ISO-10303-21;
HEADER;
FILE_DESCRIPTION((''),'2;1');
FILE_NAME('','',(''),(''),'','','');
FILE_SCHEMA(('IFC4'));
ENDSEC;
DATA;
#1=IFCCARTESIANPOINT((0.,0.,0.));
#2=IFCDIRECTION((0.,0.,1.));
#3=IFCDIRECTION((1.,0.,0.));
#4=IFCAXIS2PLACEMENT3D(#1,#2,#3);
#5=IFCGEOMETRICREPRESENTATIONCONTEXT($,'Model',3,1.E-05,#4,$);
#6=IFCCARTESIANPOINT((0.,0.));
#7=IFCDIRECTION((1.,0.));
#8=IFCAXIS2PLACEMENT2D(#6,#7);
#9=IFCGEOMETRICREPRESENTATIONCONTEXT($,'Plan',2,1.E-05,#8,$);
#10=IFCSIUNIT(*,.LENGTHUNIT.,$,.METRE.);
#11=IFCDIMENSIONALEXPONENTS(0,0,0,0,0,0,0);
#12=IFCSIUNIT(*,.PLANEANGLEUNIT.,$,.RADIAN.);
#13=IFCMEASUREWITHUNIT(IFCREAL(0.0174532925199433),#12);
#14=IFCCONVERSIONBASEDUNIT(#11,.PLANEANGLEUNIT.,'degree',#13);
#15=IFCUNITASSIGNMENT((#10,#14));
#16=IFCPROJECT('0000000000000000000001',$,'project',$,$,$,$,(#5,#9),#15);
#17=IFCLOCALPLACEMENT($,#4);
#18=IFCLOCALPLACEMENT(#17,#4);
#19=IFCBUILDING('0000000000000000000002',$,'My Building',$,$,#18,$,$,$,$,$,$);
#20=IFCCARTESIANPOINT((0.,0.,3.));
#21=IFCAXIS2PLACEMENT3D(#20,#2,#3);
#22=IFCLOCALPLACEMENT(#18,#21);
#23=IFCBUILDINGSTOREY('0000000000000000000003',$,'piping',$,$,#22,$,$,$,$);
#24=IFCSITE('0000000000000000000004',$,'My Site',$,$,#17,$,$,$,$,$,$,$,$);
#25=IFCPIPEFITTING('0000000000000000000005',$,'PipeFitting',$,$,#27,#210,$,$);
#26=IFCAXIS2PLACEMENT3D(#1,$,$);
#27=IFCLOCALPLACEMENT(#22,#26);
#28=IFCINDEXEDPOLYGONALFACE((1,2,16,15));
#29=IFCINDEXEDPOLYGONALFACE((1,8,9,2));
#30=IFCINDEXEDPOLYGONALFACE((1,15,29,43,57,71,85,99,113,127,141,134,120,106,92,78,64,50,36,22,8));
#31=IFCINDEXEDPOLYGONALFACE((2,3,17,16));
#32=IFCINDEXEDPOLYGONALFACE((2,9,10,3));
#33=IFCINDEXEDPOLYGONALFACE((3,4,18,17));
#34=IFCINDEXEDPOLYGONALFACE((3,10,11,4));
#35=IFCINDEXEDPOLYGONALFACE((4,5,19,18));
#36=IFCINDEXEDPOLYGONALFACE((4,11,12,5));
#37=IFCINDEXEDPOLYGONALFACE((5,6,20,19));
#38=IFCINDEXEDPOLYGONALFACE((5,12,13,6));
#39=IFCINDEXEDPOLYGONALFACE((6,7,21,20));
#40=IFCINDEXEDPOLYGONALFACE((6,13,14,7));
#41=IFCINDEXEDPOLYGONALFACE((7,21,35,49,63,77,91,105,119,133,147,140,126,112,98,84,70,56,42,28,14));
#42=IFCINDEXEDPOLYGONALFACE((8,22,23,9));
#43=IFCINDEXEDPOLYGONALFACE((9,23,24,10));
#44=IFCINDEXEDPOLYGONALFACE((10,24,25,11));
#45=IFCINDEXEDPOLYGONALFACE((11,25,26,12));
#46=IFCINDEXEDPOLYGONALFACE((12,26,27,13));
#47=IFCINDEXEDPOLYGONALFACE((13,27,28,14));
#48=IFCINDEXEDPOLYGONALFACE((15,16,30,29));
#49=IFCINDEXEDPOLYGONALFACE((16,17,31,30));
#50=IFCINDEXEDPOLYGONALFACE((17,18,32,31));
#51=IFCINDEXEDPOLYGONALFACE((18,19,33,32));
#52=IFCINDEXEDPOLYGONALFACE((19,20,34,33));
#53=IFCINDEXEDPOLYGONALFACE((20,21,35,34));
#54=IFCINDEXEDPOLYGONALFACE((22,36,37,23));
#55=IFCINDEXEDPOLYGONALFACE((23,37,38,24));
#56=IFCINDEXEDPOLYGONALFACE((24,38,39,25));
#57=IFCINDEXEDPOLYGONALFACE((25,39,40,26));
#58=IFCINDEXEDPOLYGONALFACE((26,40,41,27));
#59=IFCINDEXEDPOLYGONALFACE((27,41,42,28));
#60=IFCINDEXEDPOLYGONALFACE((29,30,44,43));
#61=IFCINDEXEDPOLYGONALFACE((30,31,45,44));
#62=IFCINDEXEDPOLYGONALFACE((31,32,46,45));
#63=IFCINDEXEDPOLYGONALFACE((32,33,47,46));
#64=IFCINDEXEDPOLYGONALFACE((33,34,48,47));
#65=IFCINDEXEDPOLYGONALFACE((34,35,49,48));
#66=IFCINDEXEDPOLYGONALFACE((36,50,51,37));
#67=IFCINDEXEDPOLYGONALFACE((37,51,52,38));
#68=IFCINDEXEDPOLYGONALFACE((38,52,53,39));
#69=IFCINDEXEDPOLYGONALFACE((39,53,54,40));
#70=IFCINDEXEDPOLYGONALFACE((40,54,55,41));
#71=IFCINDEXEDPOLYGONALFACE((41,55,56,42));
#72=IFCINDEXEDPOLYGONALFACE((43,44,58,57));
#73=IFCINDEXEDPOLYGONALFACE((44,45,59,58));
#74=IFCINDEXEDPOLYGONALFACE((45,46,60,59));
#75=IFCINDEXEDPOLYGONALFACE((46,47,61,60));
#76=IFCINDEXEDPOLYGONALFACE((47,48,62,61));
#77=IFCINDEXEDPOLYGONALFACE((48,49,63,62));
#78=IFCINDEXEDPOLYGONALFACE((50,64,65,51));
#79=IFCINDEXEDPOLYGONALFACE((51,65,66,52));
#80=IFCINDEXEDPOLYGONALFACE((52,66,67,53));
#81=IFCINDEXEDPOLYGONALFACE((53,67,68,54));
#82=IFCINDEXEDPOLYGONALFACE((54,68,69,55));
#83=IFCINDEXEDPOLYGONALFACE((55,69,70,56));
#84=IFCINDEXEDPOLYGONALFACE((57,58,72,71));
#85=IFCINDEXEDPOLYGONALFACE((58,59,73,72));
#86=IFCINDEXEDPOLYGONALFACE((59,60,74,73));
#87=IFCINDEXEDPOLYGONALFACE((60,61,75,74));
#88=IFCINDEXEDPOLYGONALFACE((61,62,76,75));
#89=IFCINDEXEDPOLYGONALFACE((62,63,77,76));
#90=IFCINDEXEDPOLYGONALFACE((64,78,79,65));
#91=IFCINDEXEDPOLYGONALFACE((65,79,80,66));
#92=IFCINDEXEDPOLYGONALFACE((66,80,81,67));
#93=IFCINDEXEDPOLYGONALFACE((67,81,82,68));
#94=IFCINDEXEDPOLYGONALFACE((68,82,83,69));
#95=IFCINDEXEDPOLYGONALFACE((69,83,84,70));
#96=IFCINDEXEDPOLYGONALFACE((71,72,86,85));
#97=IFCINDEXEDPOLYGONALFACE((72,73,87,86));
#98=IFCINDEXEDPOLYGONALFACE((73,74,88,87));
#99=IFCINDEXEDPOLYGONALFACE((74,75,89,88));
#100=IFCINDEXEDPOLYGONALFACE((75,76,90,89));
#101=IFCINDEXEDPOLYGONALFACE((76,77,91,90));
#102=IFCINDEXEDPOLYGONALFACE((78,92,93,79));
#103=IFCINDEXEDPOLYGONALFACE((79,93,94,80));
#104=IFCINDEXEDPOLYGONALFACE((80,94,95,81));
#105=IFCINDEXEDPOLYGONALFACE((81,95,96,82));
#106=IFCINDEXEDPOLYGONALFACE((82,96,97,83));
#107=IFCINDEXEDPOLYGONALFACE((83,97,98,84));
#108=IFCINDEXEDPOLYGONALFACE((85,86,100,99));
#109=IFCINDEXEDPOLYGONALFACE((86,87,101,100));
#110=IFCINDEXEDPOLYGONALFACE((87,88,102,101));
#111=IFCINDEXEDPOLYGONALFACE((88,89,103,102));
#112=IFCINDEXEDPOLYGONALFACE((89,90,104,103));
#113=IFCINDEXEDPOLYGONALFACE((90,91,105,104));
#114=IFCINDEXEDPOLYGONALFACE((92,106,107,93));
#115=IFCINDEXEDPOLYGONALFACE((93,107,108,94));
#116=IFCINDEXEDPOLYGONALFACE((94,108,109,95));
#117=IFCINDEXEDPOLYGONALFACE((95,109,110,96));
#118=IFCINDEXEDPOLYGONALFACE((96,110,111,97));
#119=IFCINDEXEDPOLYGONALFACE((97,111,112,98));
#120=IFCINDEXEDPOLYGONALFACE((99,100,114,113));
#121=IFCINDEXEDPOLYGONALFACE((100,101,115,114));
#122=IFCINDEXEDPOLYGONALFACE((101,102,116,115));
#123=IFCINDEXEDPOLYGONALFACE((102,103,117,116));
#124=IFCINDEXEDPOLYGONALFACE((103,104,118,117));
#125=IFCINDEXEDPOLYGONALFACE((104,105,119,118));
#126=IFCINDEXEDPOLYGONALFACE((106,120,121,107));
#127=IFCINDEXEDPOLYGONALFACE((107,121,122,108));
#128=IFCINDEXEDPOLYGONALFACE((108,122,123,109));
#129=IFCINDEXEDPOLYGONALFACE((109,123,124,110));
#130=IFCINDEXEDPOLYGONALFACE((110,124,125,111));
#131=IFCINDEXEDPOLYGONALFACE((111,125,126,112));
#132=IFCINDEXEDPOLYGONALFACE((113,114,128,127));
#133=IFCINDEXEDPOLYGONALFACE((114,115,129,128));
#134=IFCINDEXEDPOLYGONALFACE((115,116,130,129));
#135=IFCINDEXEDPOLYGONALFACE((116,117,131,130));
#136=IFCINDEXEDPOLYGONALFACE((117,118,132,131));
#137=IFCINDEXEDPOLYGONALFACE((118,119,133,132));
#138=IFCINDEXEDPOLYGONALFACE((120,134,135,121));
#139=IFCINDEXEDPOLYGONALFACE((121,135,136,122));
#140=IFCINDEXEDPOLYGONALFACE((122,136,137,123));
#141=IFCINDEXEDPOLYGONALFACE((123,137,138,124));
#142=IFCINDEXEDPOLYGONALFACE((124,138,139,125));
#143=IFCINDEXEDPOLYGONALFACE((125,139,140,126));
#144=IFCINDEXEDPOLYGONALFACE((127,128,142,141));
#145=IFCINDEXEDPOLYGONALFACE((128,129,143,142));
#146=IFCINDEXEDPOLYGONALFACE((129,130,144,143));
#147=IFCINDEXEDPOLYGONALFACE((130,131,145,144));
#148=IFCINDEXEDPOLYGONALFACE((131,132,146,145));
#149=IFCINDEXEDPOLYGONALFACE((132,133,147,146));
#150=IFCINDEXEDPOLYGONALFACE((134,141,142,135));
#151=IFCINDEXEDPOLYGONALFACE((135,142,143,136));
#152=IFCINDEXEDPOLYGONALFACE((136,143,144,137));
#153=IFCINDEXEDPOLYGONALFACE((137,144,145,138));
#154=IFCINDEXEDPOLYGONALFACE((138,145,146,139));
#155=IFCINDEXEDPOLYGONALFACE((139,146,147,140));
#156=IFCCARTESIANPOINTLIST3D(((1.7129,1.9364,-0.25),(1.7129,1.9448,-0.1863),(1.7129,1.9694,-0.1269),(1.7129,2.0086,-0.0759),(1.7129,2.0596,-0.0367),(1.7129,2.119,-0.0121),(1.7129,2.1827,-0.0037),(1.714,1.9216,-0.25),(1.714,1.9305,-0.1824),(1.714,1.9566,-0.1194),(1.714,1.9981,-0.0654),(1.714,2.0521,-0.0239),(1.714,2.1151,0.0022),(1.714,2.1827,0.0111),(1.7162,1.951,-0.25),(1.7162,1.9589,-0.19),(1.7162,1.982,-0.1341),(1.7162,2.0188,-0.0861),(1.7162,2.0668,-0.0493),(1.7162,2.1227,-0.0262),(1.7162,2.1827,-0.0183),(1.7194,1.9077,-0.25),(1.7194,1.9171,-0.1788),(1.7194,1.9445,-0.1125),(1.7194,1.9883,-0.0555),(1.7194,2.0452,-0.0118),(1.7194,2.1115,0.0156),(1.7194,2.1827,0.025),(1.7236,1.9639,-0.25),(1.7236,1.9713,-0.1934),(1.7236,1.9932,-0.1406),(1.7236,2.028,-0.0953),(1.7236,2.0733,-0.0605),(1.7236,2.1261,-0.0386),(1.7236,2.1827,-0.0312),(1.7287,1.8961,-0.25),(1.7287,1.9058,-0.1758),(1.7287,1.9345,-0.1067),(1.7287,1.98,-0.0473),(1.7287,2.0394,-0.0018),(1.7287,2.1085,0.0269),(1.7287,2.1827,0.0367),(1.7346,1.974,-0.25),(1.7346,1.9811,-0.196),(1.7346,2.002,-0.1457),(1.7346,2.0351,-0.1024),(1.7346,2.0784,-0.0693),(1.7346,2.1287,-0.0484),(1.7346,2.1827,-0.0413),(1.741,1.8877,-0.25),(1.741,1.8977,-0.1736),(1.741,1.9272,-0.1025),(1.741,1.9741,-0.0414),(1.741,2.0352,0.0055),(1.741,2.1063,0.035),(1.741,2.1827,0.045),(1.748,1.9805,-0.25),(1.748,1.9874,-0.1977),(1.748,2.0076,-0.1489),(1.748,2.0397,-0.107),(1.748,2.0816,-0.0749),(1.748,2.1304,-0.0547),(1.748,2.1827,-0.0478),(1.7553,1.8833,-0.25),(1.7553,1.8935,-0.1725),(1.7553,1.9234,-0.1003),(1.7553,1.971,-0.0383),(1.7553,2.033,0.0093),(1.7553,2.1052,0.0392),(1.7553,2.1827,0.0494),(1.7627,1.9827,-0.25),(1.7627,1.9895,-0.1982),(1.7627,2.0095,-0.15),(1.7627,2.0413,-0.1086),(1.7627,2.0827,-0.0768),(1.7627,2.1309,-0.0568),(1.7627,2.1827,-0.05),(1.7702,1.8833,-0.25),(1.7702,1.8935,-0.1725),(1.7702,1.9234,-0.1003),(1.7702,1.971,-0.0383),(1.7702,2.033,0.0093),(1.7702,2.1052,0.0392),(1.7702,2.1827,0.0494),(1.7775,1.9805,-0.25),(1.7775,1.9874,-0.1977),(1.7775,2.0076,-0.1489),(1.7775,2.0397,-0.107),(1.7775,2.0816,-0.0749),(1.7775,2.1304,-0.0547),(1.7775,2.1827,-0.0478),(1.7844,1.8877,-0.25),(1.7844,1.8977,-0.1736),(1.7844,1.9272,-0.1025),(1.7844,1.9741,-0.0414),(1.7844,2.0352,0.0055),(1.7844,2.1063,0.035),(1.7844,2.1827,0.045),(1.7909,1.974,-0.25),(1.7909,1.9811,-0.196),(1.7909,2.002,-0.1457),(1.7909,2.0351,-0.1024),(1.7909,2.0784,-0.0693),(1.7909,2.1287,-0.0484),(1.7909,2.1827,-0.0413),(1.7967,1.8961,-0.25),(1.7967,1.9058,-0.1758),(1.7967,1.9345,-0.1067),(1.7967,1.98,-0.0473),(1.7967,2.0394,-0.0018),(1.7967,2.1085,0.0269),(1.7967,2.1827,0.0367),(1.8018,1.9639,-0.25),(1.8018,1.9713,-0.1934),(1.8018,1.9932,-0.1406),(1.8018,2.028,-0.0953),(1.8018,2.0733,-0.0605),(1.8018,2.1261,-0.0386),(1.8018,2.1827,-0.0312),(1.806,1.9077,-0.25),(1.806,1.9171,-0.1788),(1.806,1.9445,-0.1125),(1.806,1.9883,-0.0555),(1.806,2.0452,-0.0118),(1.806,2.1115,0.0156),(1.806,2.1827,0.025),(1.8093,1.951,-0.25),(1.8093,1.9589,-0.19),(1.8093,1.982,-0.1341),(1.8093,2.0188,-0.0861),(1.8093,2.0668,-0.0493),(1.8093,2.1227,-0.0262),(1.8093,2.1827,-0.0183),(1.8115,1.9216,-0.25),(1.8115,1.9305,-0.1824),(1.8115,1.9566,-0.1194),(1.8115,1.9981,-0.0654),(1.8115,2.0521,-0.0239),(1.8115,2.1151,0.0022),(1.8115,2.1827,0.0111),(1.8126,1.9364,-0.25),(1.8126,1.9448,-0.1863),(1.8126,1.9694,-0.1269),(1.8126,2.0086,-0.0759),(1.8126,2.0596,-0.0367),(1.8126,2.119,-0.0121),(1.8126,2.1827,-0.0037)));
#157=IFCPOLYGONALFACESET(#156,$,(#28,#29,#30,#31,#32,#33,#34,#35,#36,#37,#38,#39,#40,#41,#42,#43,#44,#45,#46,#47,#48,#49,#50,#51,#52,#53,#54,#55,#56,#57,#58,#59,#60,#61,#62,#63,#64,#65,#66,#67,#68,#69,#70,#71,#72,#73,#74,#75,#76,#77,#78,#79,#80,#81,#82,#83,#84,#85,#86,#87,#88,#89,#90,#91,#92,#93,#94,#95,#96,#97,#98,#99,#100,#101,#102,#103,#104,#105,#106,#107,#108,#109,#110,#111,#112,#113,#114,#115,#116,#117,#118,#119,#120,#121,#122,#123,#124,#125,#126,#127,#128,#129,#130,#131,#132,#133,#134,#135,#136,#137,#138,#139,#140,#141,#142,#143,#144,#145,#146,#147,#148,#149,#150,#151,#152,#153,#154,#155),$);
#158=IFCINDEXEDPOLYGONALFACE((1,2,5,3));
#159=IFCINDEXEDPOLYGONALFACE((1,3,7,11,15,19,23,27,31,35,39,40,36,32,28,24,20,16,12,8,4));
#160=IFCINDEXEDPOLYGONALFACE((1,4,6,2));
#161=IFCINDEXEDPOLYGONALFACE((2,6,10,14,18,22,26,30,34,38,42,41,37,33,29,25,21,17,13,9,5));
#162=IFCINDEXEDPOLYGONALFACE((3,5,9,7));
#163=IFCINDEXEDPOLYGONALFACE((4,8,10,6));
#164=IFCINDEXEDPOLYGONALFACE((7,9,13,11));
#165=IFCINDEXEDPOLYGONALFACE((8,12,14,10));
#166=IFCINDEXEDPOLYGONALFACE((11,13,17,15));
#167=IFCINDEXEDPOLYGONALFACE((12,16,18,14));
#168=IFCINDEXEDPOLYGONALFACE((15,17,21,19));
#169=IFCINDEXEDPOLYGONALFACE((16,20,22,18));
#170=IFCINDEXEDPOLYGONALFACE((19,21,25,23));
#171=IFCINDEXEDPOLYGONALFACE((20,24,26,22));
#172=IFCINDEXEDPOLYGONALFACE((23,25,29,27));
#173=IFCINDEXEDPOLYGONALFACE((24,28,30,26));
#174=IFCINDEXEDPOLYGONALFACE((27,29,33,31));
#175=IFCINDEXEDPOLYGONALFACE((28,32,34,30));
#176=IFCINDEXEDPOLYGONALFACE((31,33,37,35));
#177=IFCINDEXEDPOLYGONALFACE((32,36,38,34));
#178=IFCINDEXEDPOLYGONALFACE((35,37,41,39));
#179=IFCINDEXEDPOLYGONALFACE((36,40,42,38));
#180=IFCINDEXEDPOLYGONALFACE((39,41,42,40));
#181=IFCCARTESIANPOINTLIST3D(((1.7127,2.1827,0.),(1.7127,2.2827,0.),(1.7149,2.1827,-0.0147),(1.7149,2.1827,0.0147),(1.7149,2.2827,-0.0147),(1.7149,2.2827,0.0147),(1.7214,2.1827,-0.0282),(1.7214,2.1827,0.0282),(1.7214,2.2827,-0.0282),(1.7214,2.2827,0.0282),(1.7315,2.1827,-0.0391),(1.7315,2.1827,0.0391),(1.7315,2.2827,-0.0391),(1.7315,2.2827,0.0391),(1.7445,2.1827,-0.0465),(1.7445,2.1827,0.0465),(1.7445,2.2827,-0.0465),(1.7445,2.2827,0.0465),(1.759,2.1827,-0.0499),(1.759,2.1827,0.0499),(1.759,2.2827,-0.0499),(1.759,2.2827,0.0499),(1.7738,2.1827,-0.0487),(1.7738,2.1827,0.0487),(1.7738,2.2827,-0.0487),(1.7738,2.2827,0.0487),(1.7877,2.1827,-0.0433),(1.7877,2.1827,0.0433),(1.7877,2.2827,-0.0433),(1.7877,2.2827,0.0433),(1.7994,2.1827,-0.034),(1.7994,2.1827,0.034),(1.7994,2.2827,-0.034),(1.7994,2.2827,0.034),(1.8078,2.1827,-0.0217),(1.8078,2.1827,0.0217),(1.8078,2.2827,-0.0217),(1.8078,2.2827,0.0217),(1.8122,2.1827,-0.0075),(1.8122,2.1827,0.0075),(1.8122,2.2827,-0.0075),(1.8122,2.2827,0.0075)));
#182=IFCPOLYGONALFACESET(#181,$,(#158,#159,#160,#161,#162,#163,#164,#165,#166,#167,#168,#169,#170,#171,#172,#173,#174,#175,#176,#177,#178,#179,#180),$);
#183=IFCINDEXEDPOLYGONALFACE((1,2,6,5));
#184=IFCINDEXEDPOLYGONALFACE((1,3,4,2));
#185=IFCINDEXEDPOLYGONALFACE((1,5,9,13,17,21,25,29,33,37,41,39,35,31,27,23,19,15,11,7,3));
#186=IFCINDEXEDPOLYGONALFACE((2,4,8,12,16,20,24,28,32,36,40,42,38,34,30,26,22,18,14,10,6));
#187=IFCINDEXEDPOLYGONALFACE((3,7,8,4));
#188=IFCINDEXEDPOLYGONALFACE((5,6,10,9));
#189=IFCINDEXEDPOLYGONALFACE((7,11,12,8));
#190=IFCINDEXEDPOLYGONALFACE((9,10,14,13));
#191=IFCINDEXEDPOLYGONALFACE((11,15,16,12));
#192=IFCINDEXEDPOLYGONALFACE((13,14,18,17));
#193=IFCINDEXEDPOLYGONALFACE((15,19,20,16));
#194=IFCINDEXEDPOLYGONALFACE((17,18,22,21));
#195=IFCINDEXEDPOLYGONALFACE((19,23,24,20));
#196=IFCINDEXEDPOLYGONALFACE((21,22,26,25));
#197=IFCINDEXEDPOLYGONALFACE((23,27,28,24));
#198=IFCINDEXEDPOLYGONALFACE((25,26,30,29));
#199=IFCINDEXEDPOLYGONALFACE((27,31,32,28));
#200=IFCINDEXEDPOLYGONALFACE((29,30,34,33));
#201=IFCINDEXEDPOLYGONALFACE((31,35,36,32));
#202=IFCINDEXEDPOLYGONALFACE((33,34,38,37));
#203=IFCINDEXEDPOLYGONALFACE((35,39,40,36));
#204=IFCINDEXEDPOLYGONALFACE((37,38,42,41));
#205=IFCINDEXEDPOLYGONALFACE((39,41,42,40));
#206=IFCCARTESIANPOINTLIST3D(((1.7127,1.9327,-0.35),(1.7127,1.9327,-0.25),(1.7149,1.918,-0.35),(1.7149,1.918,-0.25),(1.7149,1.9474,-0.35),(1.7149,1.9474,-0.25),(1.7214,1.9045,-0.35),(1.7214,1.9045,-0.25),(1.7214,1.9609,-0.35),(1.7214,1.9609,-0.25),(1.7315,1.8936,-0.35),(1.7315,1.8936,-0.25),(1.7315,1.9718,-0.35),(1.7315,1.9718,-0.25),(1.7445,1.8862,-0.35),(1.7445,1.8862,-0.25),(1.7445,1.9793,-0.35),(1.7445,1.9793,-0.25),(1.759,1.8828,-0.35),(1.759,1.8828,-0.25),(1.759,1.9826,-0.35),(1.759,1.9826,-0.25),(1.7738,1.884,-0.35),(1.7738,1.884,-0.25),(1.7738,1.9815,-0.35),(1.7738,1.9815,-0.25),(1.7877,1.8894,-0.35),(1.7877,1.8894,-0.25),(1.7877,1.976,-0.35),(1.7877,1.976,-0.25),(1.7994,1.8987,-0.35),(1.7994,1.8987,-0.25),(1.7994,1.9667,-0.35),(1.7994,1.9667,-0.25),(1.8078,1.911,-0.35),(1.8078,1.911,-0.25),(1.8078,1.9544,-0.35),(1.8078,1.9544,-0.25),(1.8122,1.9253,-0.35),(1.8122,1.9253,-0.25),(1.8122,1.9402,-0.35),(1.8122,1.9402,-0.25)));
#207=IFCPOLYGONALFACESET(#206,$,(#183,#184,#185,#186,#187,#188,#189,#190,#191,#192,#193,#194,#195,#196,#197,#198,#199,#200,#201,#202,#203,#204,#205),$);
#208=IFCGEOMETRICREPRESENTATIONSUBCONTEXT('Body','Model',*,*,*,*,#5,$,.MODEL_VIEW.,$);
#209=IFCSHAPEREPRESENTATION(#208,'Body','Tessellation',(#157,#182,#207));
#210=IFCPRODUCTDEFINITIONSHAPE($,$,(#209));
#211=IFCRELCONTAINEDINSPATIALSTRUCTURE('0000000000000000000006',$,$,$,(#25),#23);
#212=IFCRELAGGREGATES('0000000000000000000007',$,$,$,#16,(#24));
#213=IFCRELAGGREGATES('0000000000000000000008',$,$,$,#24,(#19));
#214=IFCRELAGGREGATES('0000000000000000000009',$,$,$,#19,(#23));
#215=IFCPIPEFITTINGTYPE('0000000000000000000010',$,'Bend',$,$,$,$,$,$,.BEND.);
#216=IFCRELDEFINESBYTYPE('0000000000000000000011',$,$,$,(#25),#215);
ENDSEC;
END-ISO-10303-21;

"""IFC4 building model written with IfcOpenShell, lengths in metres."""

from ifc_helpers import new_model, entity, si_unit, converted_unit, frame, origin_with_axes, origin_2d_with_axis, place, context, subcontext, project, spatial, circle, extrude, source, transform, mapped, type_object, type_shapes, element, save


model = new_model("IFC4")

# Units and contexts
model_context = context("Model", 3, precision=1e-05, world=origin_with_axes())
plan_context = context("Plan", 2, precision=1e-05, world=origin_2d_with_axis())
body_context = subcontext(model_context, "Body", "Model", "MODEL_VIEW")
ifc_project = project(units=[si_unit("LENGTHUNIT", "METRE"), converted_unit("PLANEANGLEUNIT", "degree", entity("IfcReal", 0.0174532925199433), si_unit("PLANEANGLEUNIT", "RADIAN"), dimensions=[0, 0, 0, 0, 0, 0, 0])], contexts=[model_context, plan_context])

# Site, building, storey
site_placement = place(None, origin_with_axes())
site = spatial("IfcSite", under=ifc_project, at=site_placement, Name="My Site")
building_placement = place(site_placement, origin_with_axes())
building = spatial("IfcBuilding", under=site, at=building_placement, Name="My Building")
storey_placement = place(building_placement, frame((0.0, 0.0, 3.0), z_axis=(0.0, 0.0, 1.0), x_axis=(1.0, 0.0, 0.0)))
storey = spatial("IfcBuildingStorey", under=building, at=storey_placement, Name="piping")

# Pipe fitting
pipe_fitting_type = type_object("IfcPipeFittingType", Name="Bend", PredefinedType="BEND")
shared_shape = source(origin_with_axes(), body_context, "Body", "SolidModel", [
    entity("IfcSweptDiskSolid", entity("IfcIndexedPolyCurve", entity("IfcCartesianPointList3D", [[0.0, 0.0, -0.1], [0.0, -0.0732, -0.2768], [0.0, -0.25, -0.35]]), [entity("IfcArcIndex", [1, 2, 3])]), 0.05),
    extrude(circle(Radius=0.05), origin_with_axes(), (0.0, 0.0, -1.0), 0.1),
    extrude(circle(Radius=0.05), frame((0.0, -0.25, -0.35), z_axis=(0.0, -1.0, 0.0), x_axis=(1.0, 0.0, 0.0)), (0.0, 0.0, 1.0), 0.1),
])
type_shapes(pipe_fitting_type, [shared_shape])
for number, where, z_axis, x_axis, name in (
    (1, (1.7627, 2.2827, 0.0), (0.0, 1.0, 0.0), (-1.0, 0.0, 0.0), "PipeFitting"),
):
    element("IfcPipeFitting", number, at=place(storey_placement, frame(where, z_axis=z_axis, x_axis=x_axis)), inside=storey, type_object=pipe_fitting_type, Name=name, context=body_context, shape_type="MappedRepresentation", body=[
        mapped(shared_shape, transform((0.0, 0.0, 0.0), x_axis=(1.0, 0.0, 0.0), y_axis=(0.0, 1.0, 0.0), z_axis=(0.0, 0.0, 1.0), scale=1.0)),
    ])

save(model, "model.ifc")
